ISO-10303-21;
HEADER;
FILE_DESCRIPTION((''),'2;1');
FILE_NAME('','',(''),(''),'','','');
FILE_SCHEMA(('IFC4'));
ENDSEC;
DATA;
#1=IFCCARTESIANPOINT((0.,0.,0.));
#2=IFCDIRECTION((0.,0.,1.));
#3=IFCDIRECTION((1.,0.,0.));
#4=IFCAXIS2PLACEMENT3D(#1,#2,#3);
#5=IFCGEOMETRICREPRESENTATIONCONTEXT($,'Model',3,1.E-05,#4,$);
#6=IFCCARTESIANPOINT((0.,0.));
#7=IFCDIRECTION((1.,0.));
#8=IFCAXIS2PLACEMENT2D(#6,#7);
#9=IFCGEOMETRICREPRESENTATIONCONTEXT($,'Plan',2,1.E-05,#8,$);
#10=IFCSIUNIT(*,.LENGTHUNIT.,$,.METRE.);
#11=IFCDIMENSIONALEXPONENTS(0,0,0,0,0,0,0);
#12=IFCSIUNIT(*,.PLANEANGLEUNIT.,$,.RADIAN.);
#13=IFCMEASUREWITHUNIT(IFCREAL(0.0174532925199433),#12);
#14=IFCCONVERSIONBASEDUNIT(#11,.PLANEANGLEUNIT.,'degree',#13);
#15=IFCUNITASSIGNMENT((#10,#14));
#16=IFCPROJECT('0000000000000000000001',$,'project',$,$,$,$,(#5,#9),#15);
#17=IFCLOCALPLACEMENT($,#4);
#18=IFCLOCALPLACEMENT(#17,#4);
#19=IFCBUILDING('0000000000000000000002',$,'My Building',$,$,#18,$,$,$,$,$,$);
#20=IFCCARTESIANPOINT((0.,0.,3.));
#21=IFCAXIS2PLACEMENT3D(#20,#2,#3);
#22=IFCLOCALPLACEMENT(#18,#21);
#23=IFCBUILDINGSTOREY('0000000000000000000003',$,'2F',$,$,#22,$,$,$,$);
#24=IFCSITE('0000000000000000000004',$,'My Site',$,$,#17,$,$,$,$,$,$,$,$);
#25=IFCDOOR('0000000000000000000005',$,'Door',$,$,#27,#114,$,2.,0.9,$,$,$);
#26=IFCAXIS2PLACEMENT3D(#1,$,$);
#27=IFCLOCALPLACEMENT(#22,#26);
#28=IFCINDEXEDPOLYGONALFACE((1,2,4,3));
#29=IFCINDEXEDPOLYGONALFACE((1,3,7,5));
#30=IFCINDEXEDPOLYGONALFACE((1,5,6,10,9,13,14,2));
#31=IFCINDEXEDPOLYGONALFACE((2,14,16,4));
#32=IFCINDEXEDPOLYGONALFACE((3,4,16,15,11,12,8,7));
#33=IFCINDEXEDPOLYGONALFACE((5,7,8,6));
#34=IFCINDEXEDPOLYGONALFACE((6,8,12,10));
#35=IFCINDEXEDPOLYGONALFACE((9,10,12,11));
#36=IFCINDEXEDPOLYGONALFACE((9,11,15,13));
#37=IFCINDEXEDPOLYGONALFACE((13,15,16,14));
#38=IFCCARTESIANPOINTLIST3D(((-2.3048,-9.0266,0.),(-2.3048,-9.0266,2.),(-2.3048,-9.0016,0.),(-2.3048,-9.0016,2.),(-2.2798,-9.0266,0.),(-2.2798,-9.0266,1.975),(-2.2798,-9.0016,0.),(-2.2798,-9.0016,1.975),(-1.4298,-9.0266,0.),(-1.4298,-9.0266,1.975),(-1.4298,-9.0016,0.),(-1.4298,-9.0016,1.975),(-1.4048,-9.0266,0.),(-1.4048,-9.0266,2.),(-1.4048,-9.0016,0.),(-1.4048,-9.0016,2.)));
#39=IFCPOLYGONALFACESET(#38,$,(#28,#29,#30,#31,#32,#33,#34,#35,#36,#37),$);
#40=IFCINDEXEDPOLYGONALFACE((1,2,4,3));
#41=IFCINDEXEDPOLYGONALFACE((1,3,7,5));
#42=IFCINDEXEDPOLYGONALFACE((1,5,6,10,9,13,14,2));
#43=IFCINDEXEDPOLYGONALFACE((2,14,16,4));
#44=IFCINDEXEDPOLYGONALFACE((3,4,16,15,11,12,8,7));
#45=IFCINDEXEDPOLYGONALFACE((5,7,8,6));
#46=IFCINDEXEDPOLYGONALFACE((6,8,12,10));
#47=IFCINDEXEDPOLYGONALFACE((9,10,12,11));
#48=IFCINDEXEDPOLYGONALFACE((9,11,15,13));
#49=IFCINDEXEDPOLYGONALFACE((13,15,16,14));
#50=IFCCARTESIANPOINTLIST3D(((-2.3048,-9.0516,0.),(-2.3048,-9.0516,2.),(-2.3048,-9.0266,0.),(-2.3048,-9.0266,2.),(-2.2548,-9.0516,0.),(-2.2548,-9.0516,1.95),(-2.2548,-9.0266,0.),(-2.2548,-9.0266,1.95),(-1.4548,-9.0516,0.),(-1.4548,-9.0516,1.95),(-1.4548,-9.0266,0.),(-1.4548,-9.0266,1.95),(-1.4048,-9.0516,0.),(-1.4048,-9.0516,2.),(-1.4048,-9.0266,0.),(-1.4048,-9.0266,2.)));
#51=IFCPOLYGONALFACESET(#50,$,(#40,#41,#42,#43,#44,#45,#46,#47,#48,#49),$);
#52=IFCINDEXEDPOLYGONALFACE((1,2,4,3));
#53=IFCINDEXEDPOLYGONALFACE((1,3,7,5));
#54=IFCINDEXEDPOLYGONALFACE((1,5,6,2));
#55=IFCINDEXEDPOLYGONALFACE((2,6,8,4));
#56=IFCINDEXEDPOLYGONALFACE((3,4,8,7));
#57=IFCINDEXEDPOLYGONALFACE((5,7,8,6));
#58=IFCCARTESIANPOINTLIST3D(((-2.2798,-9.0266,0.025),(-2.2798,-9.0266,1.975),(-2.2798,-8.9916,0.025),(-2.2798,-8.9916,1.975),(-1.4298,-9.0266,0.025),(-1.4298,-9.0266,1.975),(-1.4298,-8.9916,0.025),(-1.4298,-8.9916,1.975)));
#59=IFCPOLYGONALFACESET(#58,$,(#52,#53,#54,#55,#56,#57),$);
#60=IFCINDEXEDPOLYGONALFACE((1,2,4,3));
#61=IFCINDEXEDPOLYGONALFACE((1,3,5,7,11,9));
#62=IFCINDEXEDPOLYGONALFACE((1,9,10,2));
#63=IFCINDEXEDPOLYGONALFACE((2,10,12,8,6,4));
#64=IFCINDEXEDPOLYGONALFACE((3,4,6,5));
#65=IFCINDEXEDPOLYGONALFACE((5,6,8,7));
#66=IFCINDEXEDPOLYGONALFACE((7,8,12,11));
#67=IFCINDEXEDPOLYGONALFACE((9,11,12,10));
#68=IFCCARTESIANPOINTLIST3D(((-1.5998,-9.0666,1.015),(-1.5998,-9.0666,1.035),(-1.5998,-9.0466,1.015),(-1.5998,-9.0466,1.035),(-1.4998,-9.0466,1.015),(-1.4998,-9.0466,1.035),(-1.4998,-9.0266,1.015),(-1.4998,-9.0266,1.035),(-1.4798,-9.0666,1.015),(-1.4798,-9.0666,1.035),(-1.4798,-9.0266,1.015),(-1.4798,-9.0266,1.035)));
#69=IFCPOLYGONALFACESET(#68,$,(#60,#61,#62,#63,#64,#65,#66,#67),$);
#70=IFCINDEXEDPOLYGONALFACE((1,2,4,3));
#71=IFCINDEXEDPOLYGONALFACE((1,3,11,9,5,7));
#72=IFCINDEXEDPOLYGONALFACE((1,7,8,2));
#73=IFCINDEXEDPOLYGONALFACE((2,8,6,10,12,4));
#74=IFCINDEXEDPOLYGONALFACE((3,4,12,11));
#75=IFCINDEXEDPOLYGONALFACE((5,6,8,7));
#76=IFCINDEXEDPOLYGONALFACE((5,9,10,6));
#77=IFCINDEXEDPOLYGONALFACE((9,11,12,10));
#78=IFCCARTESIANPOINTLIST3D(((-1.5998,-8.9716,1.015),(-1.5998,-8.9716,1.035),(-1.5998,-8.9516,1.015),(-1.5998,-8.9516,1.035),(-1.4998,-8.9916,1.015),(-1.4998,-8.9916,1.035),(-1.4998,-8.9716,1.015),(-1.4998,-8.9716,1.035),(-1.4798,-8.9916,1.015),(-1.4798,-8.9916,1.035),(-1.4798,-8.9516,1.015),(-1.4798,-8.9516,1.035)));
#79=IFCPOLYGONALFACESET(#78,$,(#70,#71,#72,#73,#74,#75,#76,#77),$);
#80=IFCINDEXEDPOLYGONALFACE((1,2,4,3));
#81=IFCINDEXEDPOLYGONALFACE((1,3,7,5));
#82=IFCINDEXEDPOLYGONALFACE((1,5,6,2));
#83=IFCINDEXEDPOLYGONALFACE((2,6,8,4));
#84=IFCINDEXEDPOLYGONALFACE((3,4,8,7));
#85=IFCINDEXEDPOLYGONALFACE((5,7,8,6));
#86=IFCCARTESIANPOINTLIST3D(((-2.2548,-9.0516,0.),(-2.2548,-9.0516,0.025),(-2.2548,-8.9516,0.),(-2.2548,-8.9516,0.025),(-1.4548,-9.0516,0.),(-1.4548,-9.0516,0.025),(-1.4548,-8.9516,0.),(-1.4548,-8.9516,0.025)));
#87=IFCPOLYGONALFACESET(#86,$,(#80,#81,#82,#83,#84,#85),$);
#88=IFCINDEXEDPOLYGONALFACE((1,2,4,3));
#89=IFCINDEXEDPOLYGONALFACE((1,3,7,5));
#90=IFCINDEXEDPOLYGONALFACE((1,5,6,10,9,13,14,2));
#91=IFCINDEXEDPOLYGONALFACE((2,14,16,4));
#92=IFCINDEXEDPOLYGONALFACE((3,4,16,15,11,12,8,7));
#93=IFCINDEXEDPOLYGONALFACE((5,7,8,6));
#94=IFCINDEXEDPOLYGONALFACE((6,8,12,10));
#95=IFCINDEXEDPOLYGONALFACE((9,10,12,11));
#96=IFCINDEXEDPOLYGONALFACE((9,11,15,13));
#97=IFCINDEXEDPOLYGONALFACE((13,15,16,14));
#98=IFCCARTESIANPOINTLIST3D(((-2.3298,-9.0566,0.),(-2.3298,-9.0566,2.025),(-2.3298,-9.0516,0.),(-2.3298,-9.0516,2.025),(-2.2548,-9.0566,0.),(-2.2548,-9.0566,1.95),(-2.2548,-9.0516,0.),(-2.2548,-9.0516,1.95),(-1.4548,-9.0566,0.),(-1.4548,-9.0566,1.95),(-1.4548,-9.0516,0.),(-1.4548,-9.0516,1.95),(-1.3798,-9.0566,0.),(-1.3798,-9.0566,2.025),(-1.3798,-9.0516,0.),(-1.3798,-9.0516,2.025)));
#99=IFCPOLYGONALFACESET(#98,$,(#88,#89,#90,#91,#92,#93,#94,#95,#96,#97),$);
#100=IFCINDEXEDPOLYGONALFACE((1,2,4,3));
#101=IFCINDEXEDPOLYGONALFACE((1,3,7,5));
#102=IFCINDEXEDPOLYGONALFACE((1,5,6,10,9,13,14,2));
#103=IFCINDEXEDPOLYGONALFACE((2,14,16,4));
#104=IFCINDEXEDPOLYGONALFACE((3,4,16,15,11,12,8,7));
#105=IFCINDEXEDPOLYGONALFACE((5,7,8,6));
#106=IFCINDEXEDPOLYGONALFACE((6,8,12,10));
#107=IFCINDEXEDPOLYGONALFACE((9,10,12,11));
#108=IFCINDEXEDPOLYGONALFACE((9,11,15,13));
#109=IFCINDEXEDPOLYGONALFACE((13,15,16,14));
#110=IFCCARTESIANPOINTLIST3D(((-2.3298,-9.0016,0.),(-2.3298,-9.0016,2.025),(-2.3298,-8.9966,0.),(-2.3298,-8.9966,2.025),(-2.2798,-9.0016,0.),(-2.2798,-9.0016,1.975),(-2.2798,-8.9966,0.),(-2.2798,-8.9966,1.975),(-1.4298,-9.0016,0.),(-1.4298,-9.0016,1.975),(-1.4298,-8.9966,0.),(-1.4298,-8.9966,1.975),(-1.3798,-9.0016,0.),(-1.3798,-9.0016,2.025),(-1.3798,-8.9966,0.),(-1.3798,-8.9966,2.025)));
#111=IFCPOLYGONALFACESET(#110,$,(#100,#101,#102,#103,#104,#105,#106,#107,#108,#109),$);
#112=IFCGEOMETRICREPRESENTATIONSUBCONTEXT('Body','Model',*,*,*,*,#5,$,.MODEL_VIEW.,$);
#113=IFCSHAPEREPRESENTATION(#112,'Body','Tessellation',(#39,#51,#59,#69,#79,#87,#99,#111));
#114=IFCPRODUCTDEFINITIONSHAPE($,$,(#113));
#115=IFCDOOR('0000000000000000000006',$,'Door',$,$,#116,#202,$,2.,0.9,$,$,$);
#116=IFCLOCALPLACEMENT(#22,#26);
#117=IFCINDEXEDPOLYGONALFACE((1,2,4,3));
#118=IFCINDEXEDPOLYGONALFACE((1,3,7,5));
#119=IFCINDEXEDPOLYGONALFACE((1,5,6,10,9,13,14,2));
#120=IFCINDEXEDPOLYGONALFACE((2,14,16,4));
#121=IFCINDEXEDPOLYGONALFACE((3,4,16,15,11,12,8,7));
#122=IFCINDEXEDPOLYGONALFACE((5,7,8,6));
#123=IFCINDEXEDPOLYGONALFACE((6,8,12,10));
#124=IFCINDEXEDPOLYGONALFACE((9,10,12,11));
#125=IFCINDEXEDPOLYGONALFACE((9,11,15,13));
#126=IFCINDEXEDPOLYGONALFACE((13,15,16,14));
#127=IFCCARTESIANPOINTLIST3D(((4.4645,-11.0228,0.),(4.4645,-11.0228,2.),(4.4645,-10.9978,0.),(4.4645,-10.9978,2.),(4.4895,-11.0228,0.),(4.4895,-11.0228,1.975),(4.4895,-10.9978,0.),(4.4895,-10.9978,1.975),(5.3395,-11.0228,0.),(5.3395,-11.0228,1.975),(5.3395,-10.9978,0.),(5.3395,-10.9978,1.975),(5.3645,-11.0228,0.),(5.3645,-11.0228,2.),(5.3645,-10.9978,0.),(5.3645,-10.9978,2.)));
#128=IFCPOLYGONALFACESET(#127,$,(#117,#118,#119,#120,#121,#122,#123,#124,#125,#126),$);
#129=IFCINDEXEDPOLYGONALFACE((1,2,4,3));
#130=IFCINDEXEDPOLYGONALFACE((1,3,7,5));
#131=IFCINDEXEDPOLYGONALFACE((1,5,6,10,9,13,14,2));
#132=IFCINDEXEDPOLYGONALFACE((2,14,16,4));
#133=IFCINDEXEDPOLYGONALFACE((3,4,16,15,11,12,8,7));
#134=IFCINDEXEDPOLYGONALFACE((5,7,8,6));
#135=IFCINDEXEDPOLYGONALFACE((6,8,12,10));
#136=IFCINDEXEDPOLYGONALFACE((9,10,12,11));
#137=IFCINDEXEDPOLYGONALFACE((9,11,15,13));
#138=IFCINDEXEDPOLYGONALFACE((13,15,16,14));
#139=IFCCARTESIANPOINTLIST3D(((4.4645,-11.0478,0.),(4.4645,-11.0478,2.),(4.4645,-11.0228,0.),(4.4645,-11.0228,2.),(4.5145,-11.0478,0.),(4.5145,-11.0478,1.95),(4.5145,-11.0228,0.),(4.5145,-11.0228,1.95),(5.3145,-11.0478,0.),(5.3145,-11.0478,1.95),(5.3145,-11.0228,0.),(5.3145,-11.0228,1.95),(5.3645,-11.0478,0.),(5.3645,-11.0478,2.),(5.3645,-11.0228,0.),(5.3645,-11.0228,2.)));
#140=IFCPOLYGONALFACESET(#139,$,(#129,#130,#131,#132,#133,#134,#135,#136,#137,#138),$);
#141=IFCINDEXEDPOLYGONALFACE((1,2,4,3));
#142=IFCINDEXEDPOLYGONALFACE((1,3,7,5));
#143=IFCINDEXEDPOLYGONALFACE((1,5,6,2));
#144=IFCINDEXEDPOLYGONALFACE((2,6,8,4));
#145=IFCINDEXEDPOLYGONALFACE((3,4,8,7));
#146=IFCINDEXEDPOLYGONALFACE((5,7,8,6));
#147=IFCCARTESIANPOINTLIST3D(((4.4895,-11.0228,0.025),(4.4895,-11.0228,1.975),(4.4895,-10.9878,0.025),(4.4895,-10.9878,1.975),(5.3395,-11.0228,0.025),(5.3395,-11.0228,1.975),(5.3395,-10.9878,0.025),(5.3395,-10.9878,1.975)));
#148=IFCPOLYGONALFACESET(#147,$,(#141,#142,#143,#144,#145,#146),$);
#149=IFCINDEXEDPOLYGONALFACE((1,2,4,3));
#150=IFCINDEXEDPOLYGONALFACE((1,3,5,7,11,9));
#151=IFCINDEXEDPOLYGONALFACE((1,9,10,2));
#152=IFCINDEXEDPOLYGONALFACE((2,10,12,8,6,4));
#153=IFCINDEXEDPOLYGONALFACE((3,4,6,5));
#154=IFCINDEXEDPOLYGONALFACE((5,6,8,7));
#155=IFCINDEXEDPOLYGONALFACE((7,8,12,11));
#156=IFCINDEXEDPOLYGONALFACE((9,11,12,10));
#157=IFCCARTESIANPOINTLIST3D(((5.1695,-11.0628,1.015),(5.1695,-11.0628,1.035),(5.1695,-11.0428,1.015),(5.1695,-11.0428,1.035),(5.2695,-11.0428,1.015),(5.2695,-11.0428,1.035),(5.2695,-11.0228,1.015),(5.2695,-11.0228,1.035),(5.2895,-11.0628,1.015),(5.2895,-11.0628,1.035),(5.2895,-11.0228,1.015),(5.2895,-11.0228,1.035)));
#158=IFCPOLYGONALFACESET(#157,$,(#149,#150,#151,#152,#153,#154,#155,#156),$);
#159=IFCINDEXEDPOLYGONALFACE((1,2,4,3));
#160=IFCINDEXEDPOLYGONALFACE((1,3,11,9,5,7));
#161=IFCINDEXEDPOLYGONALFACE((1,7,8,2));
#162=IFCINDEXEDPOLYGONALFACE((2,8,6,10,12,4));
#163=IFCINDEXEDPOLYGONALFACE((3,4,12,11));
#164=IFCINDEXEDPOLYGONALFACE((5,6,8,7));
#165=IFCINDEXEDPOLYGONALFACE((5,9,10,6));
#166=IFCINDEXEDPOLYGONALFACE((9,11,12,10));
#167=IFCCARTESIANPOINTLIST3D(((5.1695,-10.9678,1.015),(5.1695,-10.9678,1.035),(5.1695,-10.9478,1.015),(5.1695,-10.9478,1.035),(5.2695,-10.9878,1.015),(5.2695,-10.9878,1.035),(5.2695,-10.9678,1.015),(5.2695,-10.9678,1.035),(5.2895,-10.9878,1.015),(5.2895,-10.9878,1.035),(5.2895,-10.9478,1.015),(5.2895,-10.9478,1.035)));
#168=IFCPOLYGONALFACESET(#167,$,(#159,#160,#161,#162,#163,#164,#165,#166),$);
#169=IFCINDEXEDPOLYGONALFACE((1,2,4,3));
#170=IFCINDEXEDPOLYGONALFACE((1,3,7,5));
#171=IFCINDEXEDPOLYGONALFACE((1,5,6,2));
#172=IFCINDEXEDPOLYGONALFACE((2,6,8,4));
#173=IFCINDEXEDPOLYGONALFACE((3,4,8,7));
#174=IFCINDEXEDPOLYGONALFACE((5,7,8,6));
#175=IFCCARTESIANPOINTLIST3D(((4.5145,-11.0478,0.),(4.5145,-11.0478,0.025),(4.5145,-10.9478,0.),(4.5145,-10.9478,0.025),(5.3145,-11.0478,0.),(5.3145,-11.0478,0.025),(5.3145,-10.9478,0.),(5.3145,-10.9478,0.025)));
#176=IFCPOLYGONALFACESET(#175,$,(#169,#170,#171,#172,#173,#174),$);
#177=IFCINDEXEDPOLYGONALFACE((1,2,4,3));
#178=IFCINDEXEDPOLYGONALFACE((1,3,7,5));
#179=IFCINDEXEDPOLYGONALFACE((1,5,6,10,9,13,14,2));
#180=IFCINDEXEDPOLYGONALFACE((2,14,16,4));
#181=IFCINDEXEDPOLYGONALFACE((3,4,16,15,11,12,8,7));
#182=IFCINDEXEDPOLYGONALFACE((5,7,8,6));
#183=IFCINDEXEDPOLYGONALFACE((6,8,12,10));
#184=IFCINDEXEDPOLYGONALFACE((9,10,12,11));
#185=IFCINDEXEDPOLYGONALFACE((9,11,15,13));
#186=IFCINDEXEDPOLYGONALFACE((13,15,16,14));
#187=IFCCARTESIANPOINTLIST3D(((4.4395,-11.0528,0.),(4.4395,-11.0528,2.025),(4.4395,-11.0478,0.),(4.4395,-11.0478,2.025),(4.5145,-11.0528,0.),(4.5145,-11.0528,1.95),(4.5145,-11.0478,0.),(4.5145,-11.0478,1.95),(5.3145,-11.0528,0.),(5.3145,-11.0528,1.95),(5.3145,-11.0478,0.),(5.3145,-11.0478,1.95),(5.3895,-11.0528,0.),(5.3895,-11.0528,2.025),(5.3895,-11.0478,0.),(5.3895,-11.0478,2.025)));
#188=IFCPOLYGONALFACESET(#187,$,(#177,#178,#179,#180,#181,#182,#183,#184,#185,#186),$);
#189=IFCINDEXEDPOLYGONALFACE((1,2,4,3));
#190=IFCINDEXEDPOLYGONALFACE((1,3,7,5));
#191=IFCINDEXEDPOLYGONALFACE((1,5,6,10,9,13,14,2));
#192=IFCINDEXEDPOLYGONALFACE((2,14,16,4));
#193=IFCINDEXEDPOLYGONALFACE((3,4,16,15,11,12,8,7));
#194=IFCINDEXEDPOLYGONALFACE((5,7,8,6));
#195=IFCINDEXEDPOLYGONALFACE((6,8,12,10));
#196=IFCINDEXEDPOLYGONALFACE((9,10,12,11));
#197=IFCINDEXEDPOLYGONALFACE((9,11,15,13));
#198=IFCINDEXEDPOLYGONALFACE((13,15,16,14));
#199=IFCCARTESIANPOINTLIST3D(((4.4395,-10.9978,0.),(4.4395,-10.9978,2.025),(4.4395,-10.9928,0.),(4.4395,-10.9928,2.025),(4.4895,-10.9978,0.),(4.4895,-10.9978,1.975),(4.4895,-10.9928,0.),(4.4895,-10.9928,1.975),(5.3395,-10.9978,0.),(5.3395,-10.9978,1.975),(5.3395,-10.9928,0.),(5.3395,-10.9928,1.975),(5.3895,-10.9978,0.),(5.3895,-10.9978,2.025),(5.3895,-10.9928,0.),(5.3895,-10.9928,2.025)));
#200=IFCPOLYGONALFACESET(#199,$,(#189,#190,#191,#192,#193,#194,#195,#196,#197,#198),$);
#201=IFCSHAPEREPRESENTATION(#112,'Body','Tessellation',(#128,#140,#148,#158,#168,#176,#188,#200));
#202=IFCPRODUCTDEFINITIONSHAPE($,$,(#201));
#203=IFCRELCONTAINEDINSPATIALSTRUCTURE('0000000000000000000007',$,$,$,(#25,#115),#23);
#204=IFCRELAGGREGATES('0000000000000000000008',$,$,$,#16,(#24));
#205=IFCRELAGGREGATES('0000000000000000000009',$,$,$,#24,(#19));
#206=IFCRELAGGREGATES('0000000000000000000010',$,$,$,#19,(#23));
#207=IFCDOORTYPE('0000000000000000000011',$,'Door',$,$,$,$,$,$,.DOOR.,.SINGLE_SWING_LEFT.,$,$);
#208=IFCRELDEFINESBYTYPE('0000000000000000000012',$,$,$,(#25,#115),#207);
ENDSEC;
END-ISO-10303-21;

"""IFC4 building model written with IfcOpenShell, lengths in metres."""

from ifc_helpers import new_model, entity, si_unit, converted_unit, frame, origin_with_axes, origin_2d_with_axis, place, context, subcontext, project, spatial, line, indexed_curve, outline, extrude, shape, source, transform, mapped, type_object, type_shapes, element, save


model = new_model("IFC4")

# Units and contexts
model_context = context("Model", 3, precision=1e-05, world=origin_with_axes())
plan_context = context("Plan", 2, precision=1e-05, world=origin_2d_with_axis())
body_context_1 = subcontext(model_context, "Body", "Model", "MODEL_VIEW")
body_context_2 = subcontext(plan_context, "Body", "Plan", "PLAN_VIEW")
ifc_project = project(units=[si_unit("LENGTHUNIT", "METRE"), converted_unit("PLANEANGLEUNIT", "degree", entity("IfcReal", 0.0174532925199433), si_unit("PLANEANGLEUNIT", "RADIAN"), dimensions=[0, 0, 0, 0, 0, 0, 0])], contexts=[model_context, plan_context])

# Site, building, storey
site_placement = place(None, origin_with_axes())
site = spatial("IfcSite", under=ifc_project, at=site_placement, Name="My Site")
building_placement = place(site_placement, origin_with_axes())
building = spatial("IfcBuilding", under=site, at=building_placement, Name="My Building")
storey_placement = place(building_placement, frame((0.0, 0.0, 3.0), z_axis=(0.0, 0.0, 1.0), x_axis=(1.0, 0.0, 0.0)))
storey = spatial("IfcBuildingStorey", under=building, at=storey_placement, Name="2F")

# Shared definitions
door_type_1 = type_object("IfcDoorType", Name="Door", OperationType="SINGLE_SWING_LEFT", PredefinedType="DOOR")
shared_shape_1 = source(origin_with_axes(), body_context_1, "Body", "SweptSolid", [
    extrude(outline(indexed_curve([(0.0, 0.0), (0.0, 2.0), (0.9, 2.0), (0.9, 0.0), (0.875, 0.0), (0.875, 1.975), (0.025, 1.975), (0.025, 0.0)], segments=[line(1, 2, 3, 4, 5, 6, 7, 8, 1)])), frame((0.0, 0.025, 0.0), z_axis=(0.0, -1.0, 0.0), x_axis=(1.0, 0.0, 0.0)), (0.0, 0.0, -1.0), 0.025),
    extrude(outline(indexed_curve([(0.0, 0.0), (0.0, 2.0), (0.9, 2.0), (0.9, 0.0), (0.85, 0.0), (0.85, 1.95), (0.05, 1.95), (0.05, 0.0)], segments=[line(1, 2, 3, 4, 5, 6, 7, 8, 1)])), frame((0.0, 0.0, 0.0), z_axis=(0.0, -1.0, 0.0), x_axis=(1.0, 0.0, 0.0)), (0.0, 0.0, -1.0), 0.025),
    extrude(outline(indexed_curve([(0.0, 0.0), (0.85, 0.0), (0.85, 0.035), (0.0, 0.035)], segments=[line(1, 2, 3, 4, 1)])), frame((0.025, 0.025, 0.025), z_axis=(0.0, 0.0, 1.0), x_axis=(1.0, 0.0, 0.0)), (0.0, 0.0, 1.0), 1.95),
    extrude(outline(indexed_curve([(0.0, 0.0), (0.0, -0.04), (-0.12, -0.04), (-0.12, -0.02), (-0.02, -0.02), (-0.02, 0.0)], segments=[line(1, 2, 3, 4, 5, 6, 1)])), frame((0.825, 0.025, 1.015), z_axis=(0.0, 0.0, 1.0), x_axis=(1.0, 0.0, 0.0)), (0.0, 0.0, 1.0), 0.02),
    extrude(outline(indexed_curve([(0.0, 0.0), (0.0, 0.04), (-0.12, 0.04), (-0.12, 0.02), (-0.02, 0.02), (-0.02, 0.0)], segments=[line(1, 2, 3, 4, 5, 6, 1)])), frame((0.825, 0.06, 1.015), z_axis=(0.0, 0.0, 1.0), x_axis=(1.0, 0.0, 0.0)), (0.0, 0.0, 1.0), 0.02),
    extrude(outline(indexed_curve([(0.0, 0.0), (0.8, 0.0), (0.8, 0.1), (0.0, 0.1)], segments=[line(1, 2, 3, 4, 1)])), frame((0.05, 0.0, 0.0), z_axis=(0.0, 0.0, 1.0), x_axis=(1.0, 0.0, 0.0)), (0.0, 0.0, 1.0), 0.025),
    extrude(outline(indexed_curve([(0.0, 0.0), (0.0, 2.025), (0.95, 2.025), (0.95, 0.0), (0.875, 0.0), (0.875, 1.95), (0.075, 1.95), (0.075, 0.0)], segments=[line(1, 2, 3, 4, 5, 6, 7, 8, 1)])), frame((-0.025, -0.005, 0.0), z_axis=(0.0, -1.0, 0.0), x_axis=(1.0, 0.0, 0.0)), (0.0, 0.0, -1.0), 0.005),
    extrude(outline(indexed_curve([(0.0, 0.0), (0.0, 2.025), (0.95, 2.025), (0.95, 0.0), (0.9, 0.0), (0.9, 1.975), (0.05, 1.975), (0.05, 0.0)], segments=[line(1, 2, 3, 4, 5, 6, 7, 8, 1)])), frame((-0.025, 0.05, 0.0), z_axis=(0.0, -1.0, 0.0), x_axis=(1.0, 0.0, 0.0)), (0.0, 0.0, -1.0), 0.005),
])
shared_shape_2 = source(origin_with_axes(), body_context_2, "Body", "Curve2D", [
    entity("IfcIndexedPolyCurve", entity("IfcCartesianPointList2D", [[0.0, 0.0], [0.0, 0.05], [0.025, 0.05], [0.025, 0.025], [0.05, 0.025], [0.05, 0.0]]), [entity("IfcLineIndex", [1, 2, 3, 4, 5, 6, 1])]),
    entity("IfcIndexedPolyCurve", entity("IfcCartesianPointList2D", [[0.9, 0.0], [0.9, 0.05], [0.875, 0.05], [0.875, 0.025], [0.85, 0.025], [0.85, 0.0]]), [entity("IfcLineIndex", [1, 2, 3, 4, 5, 6, 1])]),
    entity("IfcTrimmedCurve", entity("IfcEllipse", entity("IfcAxis2Placement2D", entity("IfcCartesianPoint", [0.06, 0.05]), entity("IfcDirection", [1.0, 0.0])), 0.815, 0.85), [entity("IfcCartesianPoint", [0.875, 0.05])], [entity("IfcCartesianPoint", [0.06, 0.9])], True, "CARTESIAN"),
    entity("IfcIndexedPolyCurve", entity("IfcCartesianPointList2D", [[0.025, 0.05], [0.06, 0.05], [0.06, 0.9], [0.025, 0.9]]), [entity("IfcLineIndex", [1, 2, 3, 4, 1])]),
])
type_shapes(door_type_1, [shared_shape_1, shared_shape_2])

# Doors
for number, where, z_axis, x_axis, name in (
    (1, (-2.3048, -9.0516, 0.0), (0.0, 0.0, 1.0), (1.0, 0.0, 0.0), "Door"),
    (2, (4.4645, -11.0478, 0.0), (0.0, 0.0, 1.0), (1.0, 0.0, 0.0), "Door"),
):
    element("IfcDoor", number, at=place(storey_placement, frame(where, z_axis=z_axis, x_axis=x_axis)), inside=storey, type_object=door_type_1, Name=name, OverallHeight=2.0, OverallWidth=0.9, shapes=[
        shape(body_context_1, "Body", "MappedRepresentation", [mapped(shared_shape_1, transform((0.0, 0.0, 0.0), x_axis=(1.0, 0.0, 0.0), y_axis=(0.0, 1.0, 0.0), z_axis=(0.0, 0.0, 1.0), scale=1.0))]),
        shape(body_context_2, "Body", "MappedRepresentation", [mapped(shared_shape_2, transform((0.0, 0.0, 0.0), x_axis=(1.0, 0.0, 0.0), y_axis=(0.0, 1.0, 0.0), z_axis=(0.0, 0.0, 1.0), scale=1.0))]),
    ])

save(model, "model.ifc")
